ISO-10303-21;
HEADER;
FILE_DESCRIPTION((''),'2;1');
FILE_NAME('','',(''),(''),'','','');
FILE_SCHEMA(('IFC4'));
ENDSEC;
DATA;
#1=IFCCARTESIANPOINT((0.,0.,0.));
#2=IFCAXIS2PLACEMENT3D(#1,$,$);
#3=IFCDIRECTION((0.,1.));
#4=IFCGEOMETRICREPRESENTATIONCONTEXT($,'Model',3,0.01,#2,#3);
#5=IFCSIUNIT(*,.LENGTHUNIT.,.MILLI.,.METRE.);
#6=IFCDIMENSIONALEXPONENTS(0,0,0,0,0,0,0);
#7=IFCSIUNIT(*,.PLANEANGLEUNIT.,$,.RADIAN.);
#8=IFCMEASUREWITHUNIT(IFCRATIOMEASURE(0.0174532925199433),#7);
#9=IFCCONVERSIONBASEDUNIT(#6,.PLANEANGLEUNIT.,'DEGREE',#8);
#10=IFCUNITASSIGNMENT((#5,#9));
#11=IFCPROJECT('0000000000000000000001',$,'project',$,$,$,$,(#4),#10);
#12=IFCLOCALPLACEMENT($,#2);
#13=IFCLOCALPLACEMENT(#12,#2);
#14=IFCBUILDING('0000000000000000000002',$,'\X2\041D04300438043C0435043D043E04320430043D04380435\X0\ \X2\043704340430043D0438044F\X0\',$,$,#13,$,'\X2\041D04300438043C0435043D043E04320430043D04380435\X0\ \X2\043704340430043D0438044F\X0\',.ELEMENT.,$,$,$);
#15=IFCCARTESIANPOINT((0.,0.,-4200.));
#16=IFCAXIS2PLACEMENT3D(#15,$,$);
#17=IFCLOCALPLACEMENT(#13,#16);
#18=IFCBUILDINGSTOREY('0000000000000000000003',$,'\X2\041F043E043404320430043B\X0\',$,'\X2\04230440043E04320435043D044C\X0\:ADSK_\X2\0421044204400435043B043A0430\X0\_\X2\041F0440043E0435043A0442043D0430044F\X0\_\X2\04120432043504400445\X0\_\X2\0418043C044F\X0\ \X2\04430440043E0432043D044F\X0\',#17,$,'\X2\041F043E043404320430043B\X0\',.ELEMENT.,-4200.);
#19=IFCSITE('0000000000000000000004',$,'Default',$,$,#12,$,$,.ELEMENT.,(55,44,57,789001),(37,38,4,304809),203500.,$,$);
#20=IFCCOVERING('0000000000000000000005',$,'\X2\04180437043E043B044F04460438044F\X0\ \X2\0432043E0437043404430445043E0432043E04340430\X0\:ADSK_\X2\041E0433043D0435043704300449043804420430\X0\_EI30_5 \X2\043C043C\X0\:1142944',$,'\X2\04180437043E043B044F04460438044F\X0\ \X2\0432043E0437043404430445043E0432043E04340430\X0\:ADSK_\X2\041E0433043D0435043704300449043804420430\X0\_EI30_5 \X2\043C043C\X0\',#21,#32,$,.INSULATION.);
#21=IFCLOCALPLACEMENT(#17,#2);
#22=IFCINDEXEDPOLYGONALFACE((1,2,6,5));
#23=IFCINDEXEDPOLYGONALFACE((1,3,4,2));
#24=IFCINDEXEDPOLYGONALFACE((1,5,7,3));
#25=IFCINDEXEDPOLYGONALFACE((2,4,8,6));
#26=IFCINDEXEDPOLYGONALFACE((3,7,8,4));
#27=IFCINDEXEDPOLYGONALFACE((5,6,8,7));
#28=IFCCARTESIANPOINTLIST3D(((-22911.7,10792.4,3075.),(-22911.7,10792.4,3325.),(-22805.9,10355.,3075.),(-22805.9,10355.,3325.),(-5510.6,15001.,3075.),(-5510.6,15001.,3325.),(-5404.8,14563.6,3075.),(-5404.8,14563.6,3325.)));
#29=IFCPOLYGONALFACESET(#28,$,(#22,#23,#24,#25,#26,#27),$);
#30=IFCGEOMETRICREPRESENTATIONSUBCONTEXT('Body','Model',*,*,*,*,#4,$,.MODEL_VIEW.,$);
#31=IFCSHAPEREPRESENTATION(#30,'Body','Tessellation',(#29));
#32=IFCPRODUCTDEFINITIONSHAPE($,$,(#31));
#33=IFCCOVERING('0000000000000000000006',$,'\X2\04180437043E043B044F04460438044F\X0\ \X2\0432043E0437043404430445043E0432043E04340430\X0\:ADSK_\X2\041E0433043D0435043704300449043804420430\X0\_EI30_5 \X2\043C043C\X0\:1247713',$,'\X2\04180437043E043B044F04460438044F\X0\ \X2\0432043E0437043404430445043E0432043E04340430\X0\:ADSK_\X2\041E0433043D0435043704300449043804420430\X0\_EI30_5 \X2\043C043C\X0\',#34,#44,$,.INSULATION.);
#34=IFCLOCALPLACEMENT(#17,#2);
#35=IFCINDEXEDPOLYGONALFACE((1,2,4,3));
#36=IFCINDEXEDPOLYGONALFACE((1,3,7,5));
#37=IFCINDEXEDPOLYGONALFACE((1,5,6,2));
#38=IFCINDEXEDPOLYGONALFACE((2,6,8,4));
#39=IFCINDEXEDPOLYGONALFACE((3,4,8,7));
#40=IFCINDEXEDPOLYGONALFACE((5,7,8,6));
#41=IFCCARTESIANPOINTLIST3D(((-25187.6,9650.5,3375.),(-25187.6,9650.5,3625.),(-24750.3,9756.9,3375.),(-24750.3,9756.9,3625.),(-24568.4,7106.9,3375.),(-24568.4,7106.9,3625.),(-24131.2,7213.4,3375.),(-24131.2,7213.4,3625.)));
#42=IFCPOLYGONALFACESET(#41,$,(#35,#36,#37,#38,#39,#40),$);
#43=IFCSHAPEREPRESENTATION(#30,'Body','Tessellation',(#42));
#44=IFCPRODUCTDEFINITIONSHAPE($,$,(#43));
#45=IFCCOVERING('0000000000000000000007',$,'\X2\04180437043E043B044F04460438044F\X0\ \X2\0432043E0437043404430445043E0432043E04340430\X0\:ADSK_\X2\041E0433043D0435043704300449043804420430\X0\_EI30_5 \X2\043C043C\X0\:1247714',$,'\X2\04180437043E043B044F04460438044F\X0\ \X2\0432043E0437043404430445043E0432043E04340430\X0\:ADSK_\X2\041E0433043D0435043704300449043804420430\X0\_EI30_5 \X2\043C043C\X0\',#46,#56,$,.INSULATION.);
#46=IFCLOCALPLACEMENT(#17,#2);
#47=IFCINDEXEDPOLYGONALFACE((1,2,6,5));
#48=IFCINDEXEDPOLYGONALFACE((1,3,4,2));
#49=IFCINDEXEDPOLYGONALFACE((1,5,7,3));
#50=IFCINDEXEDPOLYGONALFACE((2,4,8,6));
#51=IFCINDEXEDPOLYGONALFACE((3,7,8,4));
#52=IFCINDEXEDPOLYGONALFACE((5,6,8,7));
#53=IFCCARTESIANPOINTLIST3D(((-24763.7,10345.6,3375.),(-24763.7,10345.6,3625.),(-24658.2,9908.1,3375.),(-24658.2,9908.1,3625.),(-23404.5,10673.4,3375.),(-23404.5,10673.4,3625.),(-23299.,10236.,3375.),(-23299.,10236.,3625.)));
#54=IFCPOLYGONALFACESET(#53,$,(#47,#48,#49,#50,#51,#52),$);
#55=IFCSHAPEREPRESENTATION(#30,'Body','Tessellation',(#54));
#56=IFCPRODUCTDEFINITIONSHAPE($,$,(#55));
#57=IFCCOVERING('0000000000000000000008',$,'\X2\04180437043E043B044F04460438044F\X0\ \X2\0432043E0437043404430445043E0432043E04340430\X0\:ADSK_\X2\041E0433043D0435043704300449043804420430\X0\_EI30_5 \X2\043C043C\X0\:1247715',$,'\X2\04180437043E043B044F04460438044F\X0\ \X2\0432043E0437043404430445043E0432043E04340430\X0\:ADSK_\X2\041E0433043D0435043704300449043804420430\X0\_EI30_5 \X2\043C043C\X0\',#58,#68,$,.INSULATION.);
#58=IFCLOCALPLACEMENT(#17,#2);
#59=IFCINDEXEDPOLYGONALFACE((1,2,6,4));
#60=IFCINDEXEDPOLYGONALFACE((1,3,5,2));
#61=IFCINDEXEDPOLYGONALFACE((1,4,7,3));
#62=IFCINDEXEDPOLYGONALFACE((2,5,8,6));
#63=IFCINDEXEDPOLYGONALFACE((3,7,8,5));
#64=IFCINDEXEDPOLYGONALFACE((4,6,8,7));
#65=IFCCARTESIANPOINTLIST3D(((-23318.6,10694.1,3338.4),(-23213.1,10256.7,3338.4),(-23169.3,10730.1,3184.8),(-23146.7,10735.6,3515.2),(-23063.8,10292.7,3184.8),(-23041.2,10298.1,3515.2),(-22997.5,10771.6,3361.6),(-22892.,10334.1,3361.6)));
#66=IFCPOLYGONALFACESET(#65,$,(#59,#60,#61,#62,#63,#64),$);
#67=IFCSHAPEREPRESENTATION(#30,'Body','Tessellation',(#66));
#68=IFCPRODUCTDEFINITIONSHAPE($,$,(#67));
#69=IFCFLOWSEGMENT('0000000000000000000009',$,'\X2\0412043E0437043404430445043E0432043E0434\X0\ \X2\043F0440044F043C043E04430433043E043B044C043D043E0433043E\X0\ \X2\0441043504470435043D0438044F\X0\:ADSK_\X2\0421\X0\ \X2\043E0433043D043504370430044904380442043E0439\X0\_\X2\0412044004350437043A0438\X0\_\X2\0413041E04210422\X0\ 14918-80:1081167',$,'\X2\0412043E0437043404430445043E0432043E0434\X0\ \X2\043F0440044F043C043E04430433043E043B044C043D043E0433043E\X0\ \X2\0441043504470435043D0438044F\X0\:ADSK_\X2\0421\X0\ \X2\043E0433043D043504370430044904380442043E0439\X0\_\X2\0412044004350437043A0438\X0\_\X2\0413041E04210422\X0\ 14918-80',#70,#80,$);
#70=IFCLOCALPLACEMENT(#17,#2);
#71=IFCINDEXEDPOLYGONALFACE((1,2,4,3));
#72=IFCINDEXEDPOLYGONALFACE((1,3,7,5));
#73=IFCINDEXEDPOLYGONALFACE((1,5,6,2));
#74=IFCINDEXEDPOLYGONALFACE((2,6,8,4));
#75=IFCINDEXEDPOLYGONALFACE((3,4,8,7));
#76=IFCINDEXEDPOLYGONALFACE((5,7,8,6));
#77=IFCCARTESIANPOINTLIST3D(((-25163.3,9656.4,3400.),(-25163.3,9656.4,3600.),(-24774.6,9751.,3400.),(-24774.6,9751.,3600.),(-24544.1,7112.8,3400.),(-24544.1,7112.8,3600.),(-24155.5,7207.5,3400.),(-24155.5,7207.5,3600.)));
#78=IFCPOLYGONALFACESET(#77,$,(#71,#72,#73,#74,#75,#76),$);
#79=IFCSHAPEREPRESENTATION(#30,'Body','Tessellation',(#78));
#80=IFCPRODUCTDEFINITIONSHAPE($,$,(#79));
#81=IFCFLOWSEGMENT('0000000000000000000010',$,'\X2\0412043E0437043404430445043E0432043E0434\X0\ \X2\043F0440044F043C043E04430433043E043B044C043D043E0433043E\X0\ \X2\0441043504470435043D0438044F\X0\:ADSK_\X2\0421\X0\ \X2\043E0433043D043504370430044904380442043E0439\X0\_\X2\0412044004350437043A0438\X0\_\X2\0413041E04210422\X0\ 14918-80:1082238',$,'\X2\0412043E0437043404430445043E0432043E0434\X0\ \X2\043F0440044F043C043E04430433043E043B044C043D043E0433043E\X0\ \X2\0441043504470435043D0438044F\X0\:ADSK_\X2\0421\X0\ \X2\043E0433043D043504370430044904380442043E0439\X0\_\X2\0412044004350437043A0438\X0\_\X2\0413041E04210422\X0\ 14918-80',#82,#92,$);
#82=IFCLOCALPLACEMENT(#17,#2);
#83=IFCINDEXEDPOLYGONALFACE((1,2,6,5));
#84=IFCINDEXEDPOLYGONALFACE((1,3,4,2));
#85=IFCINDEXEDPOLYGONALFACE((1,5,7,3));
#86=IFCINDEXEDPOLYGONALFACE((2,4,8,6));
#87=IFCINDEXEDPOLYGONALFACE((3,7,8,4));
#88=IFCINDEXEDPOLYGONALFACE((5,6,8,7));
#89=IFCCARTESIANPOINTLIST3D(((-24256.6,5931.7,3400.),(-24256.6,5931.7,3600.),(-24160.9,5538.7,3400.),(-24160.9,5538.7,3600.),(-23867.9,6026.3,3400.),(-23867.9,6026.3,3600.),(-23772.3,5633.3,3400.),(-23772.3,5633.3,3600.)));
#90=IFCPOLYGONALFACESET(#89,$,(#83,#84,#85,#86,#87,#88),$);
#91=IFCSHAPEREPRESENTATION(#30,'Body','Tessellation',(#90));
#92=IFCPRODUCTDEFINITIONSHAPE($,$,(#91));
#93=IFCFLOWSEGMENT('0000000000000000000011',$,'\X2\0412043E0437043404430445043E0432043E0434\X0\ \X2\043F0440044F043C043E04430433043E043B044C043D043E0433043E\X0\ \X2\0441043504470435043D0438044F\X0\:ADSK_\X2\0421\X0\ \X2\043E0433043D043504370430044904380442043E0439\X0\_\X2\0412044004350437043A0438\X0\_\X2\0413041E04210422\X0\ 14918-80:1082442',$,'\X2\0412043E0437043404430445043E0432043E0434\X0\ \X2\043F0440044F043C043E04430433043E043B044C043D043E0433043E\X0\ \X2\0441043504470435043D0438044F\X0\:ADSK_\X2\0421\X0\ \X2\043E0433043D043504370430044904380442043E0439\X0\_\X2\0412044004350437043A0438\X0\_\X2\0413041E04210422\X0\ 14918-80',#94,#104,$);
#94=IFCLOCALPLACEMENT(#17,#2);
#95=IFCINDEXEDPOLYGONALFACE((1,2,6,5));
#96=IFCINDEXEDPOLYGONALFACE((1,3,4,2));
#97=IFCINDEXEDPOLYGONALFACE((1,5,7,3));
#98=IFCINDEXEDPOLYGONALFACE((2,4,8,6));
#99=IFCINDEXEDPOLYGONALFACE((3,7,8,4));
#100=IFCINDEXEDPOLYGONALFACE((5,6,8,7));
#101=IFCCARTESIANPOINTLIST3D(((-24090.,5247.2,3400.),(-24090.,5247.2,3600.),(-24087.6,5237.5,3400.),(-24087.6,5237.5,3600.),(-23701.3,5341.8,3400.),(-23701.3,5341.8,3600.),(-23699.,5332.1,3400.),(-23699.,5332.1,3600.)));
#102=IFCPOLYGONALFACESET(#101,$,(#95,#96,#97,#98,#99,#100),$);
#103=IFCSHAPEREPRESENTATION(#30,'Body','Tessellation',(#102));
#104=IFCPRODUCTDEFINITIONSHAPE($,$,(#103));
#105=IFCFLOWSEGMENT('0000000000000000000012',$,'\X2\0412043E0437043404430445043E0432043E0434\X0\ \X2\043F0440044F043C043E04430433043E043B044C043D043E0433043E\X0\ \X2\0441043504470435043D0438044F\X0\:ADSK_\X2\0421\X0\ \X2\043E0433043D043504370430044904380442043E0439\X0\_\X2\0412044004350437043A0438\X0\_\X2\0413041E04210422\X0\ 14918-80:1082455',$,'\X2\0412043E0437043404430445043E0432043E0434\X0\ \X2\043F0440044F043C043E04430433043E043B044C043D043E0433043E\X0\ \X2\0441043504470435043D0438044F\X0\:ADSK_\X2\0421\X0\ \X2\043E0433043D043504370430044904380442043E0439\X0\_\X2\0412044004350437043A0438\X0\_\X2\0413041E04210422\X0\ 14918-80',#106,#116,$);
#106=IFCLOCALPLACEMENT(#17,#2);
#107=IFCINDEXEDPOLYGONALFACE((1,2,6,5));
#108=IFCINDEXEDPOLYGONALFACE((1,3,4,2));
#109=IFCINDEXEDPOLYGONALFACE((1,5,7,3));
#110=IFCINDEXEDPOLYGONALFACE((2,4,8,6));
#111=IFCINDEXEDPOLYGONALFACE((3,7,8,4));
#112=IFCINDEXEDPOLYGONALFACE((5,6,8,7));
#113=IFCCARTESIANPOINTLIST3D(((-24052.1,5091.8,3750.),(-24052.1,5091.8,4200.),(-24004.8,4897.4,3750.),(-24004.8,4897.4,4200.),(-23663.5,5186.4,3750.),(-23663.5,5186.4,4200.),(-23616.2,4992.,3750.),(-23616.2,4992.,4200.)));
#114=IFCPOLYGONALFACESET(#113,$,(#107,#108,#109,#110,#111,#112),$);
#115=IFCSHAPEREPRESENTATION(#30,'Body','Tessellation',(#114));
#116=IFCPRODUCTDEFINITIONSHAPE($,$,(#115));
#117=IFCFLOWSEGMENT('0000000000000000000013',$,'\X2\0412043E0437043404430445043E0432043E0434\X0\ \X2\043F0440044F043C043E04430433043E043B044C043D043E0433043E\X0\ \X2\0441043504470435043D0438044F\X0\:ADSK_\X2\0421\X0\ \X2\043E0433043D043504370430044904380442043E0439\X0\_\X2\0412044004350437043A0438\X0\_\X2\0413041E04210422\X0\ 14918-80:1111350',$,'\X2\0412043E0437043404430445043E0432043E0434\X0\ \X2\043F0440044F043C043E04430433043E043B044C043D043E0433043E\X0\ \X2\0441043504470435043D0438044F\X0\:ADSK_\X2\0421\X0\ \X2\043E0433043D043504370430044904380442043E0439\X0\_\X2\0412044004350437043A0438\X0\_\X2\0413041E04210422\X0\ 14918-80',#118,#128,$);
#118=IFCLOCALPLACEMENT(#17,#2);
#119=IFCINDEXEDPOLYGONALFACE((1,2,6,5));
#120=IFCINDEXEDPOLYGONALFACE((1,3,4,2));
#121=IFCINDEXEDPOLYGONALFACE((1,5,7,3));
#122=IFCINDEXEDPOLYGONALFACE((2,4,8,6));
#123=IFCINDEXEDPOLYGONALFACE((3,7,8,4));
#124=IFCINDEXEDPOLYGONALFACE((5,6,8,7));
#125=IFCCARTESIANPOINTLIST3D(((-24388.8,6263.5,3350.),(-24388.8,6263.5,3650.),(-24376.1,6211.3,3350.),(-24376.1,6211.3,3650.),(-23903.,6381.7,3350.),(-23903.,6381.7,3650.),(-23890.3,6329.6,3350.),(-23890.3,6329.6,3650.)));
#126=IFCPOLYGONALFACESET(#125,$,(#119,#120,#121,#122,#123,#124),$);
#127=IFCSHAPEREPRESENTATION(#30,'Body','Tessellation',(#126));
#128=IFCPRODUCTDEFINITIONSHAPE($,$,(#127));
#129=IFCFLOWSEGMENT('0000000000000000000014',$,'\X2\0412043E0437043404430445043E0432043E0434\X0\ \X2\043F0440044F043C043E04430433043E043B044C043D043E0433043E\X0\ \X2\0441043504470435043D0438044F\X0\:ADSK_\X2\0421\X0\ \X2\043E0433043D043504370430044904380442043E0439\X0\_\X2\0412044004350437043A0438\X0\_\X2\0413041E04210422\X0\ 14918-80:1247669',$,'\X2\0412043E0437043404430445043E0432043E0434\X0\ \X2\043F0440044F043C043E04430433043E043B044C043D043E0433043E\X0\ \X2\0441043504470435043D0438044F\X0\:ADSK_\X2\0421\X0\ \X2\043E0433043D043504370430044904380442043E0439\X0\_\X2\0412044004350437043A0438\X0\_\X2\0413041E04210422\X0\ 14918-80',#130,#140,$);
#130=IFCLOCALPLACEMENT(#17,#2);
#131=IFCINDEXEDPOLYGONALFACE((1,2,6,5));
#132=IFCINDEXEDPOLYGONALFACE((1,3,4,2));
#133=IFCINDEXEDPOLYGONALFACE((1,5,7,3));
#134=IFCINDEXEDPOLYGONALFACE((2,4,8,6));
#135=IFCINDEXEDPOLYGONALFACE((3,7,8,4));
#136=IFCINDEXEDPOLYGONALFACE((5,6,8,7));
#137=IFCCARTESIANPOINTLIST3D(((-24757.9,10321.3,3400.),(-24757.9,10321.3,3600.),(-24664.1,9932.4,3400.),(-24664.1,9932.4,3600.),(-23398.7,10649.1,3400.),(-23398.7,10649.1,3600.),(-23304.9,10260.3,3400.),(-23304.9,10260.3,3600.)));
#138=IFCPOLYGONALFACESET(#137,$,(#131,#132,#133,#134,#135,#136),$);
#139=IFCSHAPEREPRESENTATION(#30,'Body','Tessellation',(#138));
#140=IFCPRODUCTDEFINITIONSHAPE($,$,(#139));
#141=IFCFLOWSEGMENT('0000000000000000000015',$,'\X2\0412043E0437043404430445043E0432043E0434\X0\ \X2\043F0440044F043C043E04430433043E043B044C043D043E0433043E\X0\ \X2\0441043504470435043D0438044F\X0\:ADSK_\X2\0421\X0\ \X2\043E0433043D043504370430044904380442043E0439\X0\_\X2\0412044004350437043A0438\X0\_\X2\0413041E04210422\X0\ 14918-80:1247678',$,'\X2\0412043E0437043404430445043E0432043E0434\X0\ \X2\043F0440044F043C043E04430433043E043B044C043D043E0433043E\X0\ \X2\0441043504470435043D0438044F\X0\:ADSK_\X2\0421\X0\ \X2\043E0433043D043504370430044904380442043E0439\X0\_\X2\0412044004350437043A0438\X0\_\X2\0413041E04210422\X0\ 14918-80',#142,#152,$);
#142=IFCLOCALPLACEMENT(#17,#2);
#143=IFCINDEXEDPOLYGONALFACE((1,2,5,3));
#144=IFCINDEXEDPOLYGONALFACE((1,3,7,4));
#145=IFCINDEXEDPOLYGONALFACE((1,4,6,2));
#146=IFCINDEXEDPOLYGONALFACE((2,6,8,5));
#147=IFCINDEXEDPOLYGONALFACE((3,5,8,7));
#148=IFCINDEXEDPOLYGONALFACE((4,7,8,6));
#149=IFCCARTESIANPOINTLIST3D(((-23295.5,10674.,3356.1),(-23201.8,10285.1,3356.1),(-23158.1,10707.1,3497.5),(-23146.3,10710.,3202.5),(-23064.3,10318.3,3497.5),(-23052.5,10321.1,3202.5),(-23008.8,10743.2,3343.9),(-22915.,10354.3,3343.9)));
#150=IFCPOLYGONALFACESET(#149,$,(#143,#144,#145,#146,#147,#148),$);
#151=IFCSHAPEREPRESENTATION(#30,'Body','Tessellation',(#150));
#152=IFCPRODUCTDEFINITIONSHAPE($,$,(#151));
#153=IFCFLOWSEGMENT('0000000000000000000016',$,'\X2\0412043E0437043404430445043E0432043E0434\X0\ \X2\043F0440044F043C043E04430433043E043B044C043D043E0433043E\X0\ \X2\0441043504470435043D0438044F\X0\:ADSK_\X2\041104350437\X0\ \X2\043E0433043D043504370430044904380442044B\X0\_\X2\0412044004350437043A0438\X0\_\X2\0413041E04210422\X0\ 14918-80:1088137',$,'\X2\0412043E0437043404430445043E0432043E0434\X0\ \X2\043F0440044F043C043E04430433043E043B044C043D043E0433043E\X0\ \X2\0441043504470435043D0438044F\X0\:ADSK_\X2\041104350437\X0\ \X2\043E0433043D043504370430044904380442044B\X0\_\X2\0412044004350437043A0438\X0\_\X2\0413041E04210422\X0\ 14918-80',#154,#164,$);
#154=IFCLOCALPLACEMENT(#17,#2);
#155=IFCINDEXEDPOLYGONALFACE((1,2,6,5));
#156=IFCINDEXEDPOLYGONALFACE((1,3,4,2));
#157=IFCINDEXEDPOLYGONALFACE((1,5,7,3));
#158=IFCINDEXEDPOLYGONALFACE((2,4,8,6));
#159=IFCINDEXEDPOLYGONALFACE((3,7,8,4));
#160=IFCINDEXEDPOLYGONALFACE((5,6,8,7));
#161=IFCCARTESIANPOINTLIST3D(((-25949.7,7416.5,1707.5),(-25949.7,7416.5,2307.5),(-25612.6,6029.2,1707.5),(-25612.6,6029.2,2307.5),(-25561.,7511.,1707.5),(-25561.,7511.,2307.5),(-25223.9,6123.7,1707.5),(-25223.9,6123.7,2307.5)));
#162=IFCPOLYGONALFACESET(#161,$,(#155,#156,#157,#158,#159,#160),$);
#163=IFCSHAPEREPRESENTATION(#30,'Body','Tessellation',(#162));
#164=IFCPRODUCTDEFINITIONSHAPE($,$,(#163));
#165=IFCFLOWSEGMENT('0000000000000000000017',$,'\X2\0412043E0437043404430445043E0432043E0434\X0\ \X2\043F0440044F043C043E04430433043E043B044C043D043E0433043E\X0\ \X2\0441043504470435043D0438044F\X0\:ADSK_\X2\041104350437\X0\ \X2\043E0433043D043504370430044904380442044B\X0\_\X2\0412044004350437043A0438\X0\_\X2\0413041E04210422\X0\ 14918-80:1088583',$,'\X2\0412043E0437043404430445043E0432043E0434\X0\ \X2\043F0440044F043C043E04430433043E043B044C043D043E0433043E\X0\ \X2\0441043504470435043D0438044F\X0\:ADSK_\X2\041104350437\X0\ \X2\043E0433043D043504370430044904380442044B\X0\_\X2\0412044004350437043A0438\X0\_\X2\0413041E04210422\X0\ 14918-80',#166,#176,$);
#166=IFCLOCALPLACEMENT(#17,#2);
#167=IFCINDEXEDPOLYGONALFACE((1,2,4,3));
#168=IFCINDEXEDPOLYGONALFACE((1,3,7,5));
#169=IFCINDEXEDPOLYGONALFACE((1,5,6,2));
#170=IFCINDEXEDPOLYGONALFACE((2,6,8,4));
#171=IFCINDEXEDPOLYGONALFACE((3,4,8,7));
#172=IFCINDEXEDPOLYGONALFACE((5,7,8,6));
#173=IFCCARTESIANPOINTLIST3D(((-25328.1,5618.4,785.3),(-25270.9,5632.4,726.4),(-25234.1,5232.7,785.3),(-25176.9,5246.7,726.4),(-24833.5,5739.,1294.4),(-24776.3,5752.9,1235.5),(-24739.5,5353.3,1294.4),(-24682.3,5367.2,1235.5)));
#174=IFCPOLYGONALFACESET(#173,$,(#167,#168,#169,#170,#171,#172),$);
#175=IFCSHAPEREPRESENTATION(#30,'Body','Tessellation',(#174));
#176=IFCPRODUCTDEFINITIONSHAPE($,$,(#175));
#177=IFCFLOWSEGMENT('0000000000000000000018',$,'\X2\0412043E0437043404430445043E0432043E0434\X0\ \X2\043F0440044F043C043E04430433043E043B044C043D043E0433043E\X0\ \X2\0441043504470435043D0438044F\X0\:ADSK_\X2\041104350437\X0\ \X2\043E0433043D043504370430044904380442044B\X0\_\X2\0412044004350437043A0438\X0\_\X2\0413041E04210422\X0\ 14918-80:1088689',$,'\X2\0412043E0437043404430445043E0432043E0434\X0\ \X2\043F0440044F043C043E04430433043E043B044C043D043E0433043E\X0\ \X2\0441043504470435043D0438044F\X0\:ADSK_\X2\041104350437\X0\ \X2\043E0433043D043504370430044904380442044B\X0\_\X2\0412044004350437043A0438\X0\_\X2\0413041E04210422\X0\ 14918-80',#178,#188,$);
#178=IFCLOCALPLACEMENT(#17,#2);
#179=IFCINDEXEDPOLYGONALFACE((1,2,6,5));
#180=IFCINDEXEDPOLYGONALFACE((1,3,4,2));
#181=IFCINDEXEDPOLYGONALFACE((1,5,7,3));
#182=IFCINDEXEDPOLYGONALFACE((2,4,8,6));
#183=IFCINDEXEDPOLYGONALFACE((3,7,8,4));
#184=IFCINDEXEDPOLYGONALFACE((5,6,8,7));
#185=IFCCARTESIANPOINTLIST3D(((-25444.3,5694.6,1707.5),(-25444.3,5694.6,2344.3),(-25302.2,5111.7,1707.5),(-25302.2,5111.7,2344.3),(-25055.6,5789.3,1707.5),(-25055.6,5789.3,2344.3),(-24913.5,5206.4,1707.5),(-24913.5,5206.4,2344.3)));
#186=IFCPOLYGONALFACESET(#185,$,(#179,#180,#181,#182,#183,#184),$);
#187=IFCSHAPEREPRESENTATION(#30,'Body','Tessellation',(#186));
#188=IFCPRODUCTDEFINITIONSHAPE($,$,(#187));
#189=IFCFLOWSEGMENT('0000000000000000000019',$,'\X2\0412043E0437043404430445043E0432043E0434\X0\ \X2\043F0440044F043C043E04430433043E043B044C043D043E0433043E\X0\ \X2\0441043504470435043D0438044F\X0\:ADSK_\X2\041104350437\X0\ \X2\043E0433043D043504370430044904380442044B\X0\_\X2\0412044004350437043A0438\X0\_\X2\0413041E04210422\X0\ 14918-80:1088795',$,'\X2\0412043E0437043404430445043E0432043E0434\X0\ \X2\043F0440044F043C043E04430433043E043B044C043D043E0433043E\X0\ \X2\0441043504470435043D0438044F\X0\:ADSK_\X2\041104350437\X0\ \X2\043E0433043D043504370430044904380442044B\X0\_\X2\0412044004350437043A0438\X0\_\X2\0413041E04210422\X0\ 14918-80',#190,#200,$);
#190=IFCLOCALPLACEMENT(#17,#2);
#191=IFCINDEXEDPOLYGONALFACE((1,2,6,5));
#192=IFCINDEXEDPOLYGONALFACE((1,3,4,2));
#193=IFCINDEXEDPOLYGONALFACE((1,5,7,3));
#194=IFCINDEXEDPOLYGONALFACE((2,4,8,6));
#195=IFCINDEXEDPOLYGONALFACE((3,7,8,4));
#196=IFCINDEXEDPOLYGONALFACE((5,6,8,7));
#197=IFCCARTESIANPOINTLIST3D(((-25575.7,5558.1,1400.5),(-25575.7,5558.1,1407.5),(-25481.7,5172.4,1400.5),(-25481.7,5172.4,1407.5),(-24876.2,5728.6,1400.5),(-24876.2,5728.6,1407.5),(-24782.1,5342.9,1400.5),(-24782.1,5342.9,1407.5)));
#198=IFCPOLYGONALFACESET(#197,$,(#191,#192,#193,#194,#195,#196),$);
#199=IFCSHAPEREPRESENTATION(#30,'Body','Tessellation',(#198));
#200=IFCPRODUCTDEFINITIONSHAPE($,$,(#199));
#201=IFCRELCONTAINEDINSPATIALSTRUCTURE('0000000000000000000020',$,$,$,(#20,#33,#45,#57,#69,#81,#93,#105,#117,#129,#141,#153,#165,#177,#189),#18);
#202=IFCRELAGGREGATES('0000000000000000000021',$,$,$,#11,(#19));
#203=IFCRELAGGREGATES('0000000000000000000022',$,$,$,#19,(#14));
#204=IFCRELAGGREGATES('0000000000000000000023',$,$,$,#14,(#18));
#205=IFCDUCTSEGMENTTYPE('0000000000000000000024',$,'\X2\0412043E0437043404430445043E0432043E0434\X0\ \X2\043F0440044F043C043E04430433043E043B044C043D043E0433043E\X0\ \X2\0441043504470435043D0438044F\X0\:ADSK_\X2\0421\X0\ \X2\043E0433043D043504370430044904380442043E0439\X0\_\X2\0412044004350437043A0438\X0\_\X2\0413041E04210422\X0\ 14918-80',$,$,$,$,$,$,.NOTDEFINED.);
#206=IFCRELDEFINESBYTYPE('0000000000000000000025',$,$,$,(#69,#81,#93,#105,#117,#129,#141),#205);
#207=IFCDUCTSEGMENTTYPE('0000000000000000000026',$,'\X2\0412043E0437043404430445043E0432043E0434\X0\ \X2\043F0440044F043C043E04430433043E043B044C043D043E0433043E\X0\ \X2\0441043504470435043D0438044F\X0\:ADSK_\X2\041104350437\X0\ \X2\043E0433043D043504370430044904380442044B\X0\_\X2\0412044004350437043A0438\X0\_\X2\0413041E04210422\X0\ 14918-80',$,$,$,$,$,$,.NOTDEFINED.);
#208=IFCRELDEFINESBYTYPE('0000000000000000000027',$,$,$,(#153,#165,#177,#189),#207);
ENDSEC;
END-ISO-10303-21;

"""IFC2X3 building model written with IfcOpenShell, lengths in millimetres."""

from ifc_helpers import new_model, entity, si_unit, converted_unit, direction, frame, frame_2d, origin, origin_2d_with_axis, place, context, subcontext, project, spatial, rectangle, extrude, type_object, element, save


model = new_model("IFC2X3")

# Units and contexts
model_context = context("Model", 3, precision=0.01, world=origin(), true_north=direction((0.0, 1.0)))
body_context = subcontext(model_context, "Body", "Model", "MODEL_VIEW")
ifc_project = project(units=[si_unit("LENGTHUNIT", "METRE", prefix="MILLI"), converted_unit("PLANEANGLEUNIT", "DEGREE", entity("IfcRatioMeasure", 0.0174532925199433), si_unit("PLANEANGLEUNIT", "RADIAN"), dimensions=[0, 0, 0, 0, 0, 0, 0])], contexts=[model_context])

# Site, building, storey
site_placement = place(None, origin())
site = spatial("IfcSite", under=ifc_project, at=site_placement, Name="Default", CompositionType="ELEMENT", RefLatitude=(55, 44, 57, 789001), RefLongitude=(37, 38, 4, 304809), RefElevation=203500.0)
building_placement = place(site_placement, origin())
building = spatial("IfcBuilding", under=site, at=building_placement, Name="Наименование здания", LongName="Наименование здания", CompositionType="ELEMENT")
storey_placement = place(building_placement, frame((0.0, 0.0, -4200.0)))
storey = spatial("IfcBuildingStorey", under=building, at=storey_placement, Name="Подвал", ObjectType="Уровень:ADSK_Стрелка_Проектная_Вверх_Имя уровня", LongName="Подвал", CompositionType="ELEMENT", Elevation=-4200.0)

# Coverings
covering_1_placement = place(storey_placement, frame((-22911.7, 10355.0, 3075.0)))
element("IfcCovering", 1, at=covering_1_placement, inside=storey, Name="Изоляция воздуховода:ADSK_Огнезащита_EI30_5 мм:1142944", ObjectType="Изоляция воздуховода:ADSK_Огнезащита_EI30_5 мм", PredefinedType="INSULATION", context=body_context, shape_type="SweptSolid", body=[
    extrude(rectangle(XDim=17902.8, YDim=450.0, at=origin_2d_with_axis()), frame((8753.4, 2323.0, 0.0), z_axis=(0.0, 0.0, 1.0), x_axis=(-0.971976, -0.235081, 0.0)), (0.0, 0.0, 1.0), 250.0),
])
covering_2_placement = place(storey_placement, frame((-25187.6, 7106.9, 3375.0)))
element("IfcCovering", 2, at=covering_2_placement, inside=storey, Name="Изоляция воздуховода:ADSK_Огнезащита_EI30_5 мм:1247713", ObjectType="Изоляция воздуховода:ADSK_Огнезащита_EI30_5 мм", PredefinedType="INSULATION", context=body_context, shape_type="SweptSolid", body=[
    extrude(rectangle(XDim=2617.9, YDim=450.0, at=origin_2d_with_axis()), frame((528.2, 1325.0, 0.0), z_axis=(0.0, 0.0, 1.0), x_axis=(-0.236518, 0.971627, 0.0)), (0.0, 0.0, 1.0), 250.0),
])
covering_3_placement = place(storey_placement, frame((-24763.7, 9908.1, 3375.0)))
element("IfcCovering", 3, at=covering_3_placement, inside=storey, Name="Изоляция воздуховода:ADSK_Огнезащита_EI30_5 мм:1247714", ObjectType="Изоляция воздуховода:ADSK_Огнезащита_EI30_5 мм", PredefinedType="INSULATION", context=body_context, shape_type="SweptSolid", body=[
    extrude(rectangle(XDim=1398.2, YDim=450.0, at=origin_2d_with_axis()), frame((732.4, 382.6, 0.0), z_axis=(0.0, 0.0, 1.0), x_axis=(-0.972125, -0.234462, 0.0)), (0.0, 0.0, 1.0), 250.0),
])
covering_4_placement = place(storey_placement, frame((-23318.6, 10256.7, 3184.8)))
element("IfcCovering", 4, at=covering_4_placement, inside=storey, Name="Изоляция воздуховода:ADSK_Огнезащита_EI30_5 мм:1247715", ObjectType="Изоляция воздуховода:ADSK_Огнезащита_EI30_5 мм", PredefinedType="INSULATION", context=body_context, shape_type="SweptSolid", body=[
    extrude(rectangle(XDim=250.0, YDim=217.2, at=frame_2d((0.0, 0.0), x_axis=(0.0, 1.0))), frame((266.1, 38.7, 165.2), z_axis=(-0.234462, 0.972125, 0.0), x_axis=(-0.687396, -0.16579, 0.707107)), (0.0, 0.0, 1.0), 450.0),
])

# Flow segments
duct_segment_type_1 = type_object("IfcDuctSegmentType", Name="Воздуховод прямоугольного сечения:ADSK_С огнезащитой_Врезки_ГОСТ 14918-80", PredefinedType="NOTDEFINED")
flow_segment_1_placement = place(storey_placement, frame((-25163.3, 7112.9, 3400.0)))
element("IfcFlowSegment", 5, at=flow_segment_1_placement, inside=storey, type_object=duct_segment_type_1, Name="Воздуховод прямоугольного сечения:ADSK_С огнезащитой_Врезки_ГОСТ 14918-80:1081167", ObjectType="Воздуховод прямоугольного сечения:ADSK_С огнезащитой_Врезки_ГОСТ 14918-80", context=body_context, shape_type="SweptSolid", body=[
    extrude(rectangle(XDim=2617.9, YDim=400.0, at=origin_2d_with_axis()), frame((503.9, 1319.1, 0.0), z_axis=(0.0, 0.0, 1.0), x_axis=(-0.236518, 0.971627, 0.0)), (0.0, 0.0, 1.0), 200.0),
])
flow_segment_2_placement = place(storey_placement, frame((-24256.6, 5538.7, 3400.0)))
element("IfcFlowSegment", 6, at=flow_segment_2_placement, inside=storey, type_object=duct_segment_type_1, Name="Воздуховод прямоугольного сечения:ADSK_С огнезащитой_Врезки_ГОСТ 14918-80:1082238", ObjectType="Воздуховод прямоугольного сечения:ADSK_С огнезащитой_Врезки_ГОСТ 14918-80", context=body_context, shape_type="SweptSolid", body=[
    extrude(rectangle(XDim=404.4, YDim=400.0, at=origin_2d_with_axis()), frame((242.2, 243.8, 0.0), z_axis=(0.0, 0.0, 1.0), x_axis=(-0.236517, 0.971627, 0.0)), (0.0, 0.0, 1.0), 200.0),
])
flow_segment_3_placement = place(storey_placement, frame((-24090.0, 5237.5, 3400.0)))
element("IfcFlowSegment", 7, at=flow_segment_3_placement, inside=storey, type_object=duct_segment_type_1, Name="Воздуховод прямоугольного сечения:ADSK_С огнезащитой_Врезки_ГОСТ 14918-80:1082442", ObjectType="Воздуховод прямоугольного сечения:ADSK_С огнезащитой_Врезки_ГОСТ 14918-80", context=body_context, shape_type="SweptSolid", body=[
    extrude(rectangle(XDim=10.0, YDim=400.0, at=origin_2d_with_axis()), frame((195.5, 52.2, 0.0), z_axis=(0.0, 0.0, 1.0), x_axis=(0.236517, -0.971627, 0.0)), (0.0, 0.0, 1.0), 200.0),
])
flow_segment_4_placement = place(storey_placement, frame((-24052.1, 4897.4, 3750.0)))
element("IfcFlowSegment", 8, at=flow_segment_4_placement, inside=storey, type_object=duct_segment_type_1, Name="Воздуховод прямоугольного сечения:ADSK_С огнезащитой_Врезки_ГОСТ 14918-80:1082455", ObjectType="Воздуховод прямоугольного сечения:ADSK_С огнезащитой_Врезки_ГОСТ 14918-80", context=body_context, shape_type="SweptSolid", body=[
    extrude(rectangle(XDim=200.0, YDim=400.0, at=origin_2d_with_axis()), frame((218.0, 144.5, 0.0), z_axis=(0.0, 0.0, 1.0), x_axis=(-0.236517, 0.971627, 0.0)), (0.0, 0.0, 1.0), 450.0),
])
flow_segment_5_placement = place(storey_placement, frame((-24388.8, 6211.3, 3350.0)))
element("IfcFlowSegment", 9, at=flow_segment_5_placement, inside=storey, type_object=duct_segment_type_1, Name="Воздуховод прямоугольного сечения:ADSK_С огнезащитой_Врезки_ГОСТ 14918-80:1111350", ObjectType="Воздуховод прямоугольного сечения:ADSK_С огнезащитой_Врезки_ГОСТ 14918-80", context=body_context, shape_type="SweptSolid", body=[
    extrude(rectangle(XDim=53.7, YDim=500.0, at=origin_2d_with_axis()), frame((249.2, 85.2, 0.0), z_axis=(0.0, 0.0, 1.0), x_axis=(0.236517, -0.971627, 0.0)), (0.0, 0.0, 1.0), 300.0),
])
flow_segment_6_placement = place(storey_placement, frame((-24757.9, 9932.4, 3400.0)))
element("IfcFlowSegment", 10, at=flow_segment_6_placement, inside=storey, type_object=duct_segment_type_1, Name="Воздуховод прямоугольного сечения:ADSK_С огнезащитой_Врезки_ГОСТ 14918-80:1247669", ObjectType="Воздуховод прямоугольного сечения:ADSK_С огнезащитой_Врезки_ГОСТ 14918-80", context=body_context, shape_type="SweptSolid", body=[
    extrude(rectangle(XDim=1398.2, YDim=400.0, at=origin_2d_with_axis()), frame((726.5, 358.3, 0.0), z_axis=(0.0, 0.0, 1.0), x_axis=(-0.972125, -0.234462, 0.0)), (0.0, 0.0, 1.0), 200.0),
])
flow_segment_7_placement = place(storey_placement, frame((-23295.5, 10285.1, 3202.5)))
element("IfcFlowSegment", 11, at=flow_segment_7_placement, inside=storey, type_object=duct_segment_type_1, Name="Воздуховод прямоугольного сечения:ADSK_С огнезащитой_Врезки_ГОСТ 14918-80:1247678", ObjectType="Воздуховод прямоугольного сечения:ADSK_С огнезащитой_Врезки_ГОСТ 14918-80", context=body_context, shape_type="SweptSolid", body=[
    extrude(rectangle(XDim=200.0, YDim=217.2, at=frame_2d((0.0, 0.0), x_axis=(0.0, 1.0))), frame((237.2, 34.6, 147.5), z_axis=(-0.234462, 0.972125, 0.0), x_axis=(-0.687396, -0.16579, 0.707107)), (0.0, 0.0, 1.0), 400.0),
])
duct_segment_type_2 = type_object("IfcDuctSegmentType", Name="Воздуховод прямоугольного сечения:ADSK_Без огнезащиты_Врезки_ГОСТ 14918-80", PredefinedType="NOTDEFINED")
flow_segment_8_placement = place(storey_placement, frame((-25949.7, 6029.2, 1707.5)))
element("IfcFlowSegment", 12, at=flow_segment_8_placement, inside=storey, type_object=duct_segment_type_2, Name="Воздуховод прямоугольного сечения:ADSK_Без огнезащиты_Врезки_ГОСТ 14918-80:1088137", ObjectType="Воздуховод прямоугольного сечения:ADSK_Без огнезащиты_Врезки_ГОСТ 14918-80", context=body_context, shape_type="SweptSolid", body=[
    extrude(rectangle(XDim=1427.7, YDim=400.0, at=origin_2d_with_axis()), frame((362.9, 740.9, 0.0), z_axis=(0.0, 0.0, 1.0), x_axis=(-0.23616, 0.971714, 0.0)), (0.0, 0.0, 1.0), 600.0),
])
flow_segment_9_placement = place(storey_placement, frame((-25328.1, 5232.7, 726.4)))
element("IfcFlowSegment", 13, at=flow_segment_9_placement, inside=storey, type_object=duct_segment_type_2, Name="Воздуховод прямоугольного сечения:ADSK_Без огнезащиты_Врезки_ГОСТ 14918-80:1088583", ObjectType="Воздуховод прямоугольного сечения:ADSK_Без огнезащиты_Врезки_ГОСТ 14918-80", context=body_context, shape_type="SweptSolid", body=[
    extrude(rectangle(XDim=83.3, YDim=397.0, at=origin_2d_with_axis()), frame((75.6, 199.8, 29.4), z_axis=(0.686992, 0.167458, 0.707107), x_axis=(-0.686992, -0.167458, 0.707107)), (0.0, 0.0, 1.0), 720.0),
])
flow_segment_10_placement = place(storey_placement, frame((-25444.3, 5111.7, 1707.5)))
element("IfcFlowSegment", 14, at=flow_segment_10_placement, inside=storey, type_object=duct_segment_type_2, Name="Воздуховод прямоугольного сечения:ADSK_Без огнезащиты_Врезки_ГОСТ 14918-80:1088689", ObjectType="Воздуховод прямоугольного сечения:ADSK_Без огнезащиты_Врезки_ГОСТ 14918-80", context=body_context, shape_type="SweptSolid", body=[
    extrude(rectangle(XDim=600.0, YDim=400.0, at=origin_2d_with_axis()), frame((265.4, 338.8, 0.0), z_axis=(0.0, 0.0, 1.0), x_axis=(0.236821, -0.971553, 0.0)), (0.0, 0.0, 1.0), 636.8),
])
flow_segment_11_placement = place(storey_placement, frame((-25575.7, 5172.4, 1400.5)))
element("IfcFlowSegment", 15, at=flow_segment_11_placement, inside=storey, type_object=duct_segment_type_2, Name="Воздуховод прямоугольного сечения:ADSK_Без огнезащиты_Врезки_ГОСТ 14918-80:1088795", ObjectType="Воздуховод прямоугольного сечения:ADSK_Без огнезащиты_Врезки_ГОСТ 14918-80", context=body_context, shape_type="SweptSolid", body=[
    extrude(rectangle(XDim=397.0, YDim=720.0, at=origin_2d_with_axis()), frame((396.8, 278.1, 0.0), z_axis=(0.0, 0.0, 1.0), x_axis=(-0.236821, 0.971553, 0.0)), (0.0, 0.0, 1.0), 7.0),
])

save(model, "model.ifc")
